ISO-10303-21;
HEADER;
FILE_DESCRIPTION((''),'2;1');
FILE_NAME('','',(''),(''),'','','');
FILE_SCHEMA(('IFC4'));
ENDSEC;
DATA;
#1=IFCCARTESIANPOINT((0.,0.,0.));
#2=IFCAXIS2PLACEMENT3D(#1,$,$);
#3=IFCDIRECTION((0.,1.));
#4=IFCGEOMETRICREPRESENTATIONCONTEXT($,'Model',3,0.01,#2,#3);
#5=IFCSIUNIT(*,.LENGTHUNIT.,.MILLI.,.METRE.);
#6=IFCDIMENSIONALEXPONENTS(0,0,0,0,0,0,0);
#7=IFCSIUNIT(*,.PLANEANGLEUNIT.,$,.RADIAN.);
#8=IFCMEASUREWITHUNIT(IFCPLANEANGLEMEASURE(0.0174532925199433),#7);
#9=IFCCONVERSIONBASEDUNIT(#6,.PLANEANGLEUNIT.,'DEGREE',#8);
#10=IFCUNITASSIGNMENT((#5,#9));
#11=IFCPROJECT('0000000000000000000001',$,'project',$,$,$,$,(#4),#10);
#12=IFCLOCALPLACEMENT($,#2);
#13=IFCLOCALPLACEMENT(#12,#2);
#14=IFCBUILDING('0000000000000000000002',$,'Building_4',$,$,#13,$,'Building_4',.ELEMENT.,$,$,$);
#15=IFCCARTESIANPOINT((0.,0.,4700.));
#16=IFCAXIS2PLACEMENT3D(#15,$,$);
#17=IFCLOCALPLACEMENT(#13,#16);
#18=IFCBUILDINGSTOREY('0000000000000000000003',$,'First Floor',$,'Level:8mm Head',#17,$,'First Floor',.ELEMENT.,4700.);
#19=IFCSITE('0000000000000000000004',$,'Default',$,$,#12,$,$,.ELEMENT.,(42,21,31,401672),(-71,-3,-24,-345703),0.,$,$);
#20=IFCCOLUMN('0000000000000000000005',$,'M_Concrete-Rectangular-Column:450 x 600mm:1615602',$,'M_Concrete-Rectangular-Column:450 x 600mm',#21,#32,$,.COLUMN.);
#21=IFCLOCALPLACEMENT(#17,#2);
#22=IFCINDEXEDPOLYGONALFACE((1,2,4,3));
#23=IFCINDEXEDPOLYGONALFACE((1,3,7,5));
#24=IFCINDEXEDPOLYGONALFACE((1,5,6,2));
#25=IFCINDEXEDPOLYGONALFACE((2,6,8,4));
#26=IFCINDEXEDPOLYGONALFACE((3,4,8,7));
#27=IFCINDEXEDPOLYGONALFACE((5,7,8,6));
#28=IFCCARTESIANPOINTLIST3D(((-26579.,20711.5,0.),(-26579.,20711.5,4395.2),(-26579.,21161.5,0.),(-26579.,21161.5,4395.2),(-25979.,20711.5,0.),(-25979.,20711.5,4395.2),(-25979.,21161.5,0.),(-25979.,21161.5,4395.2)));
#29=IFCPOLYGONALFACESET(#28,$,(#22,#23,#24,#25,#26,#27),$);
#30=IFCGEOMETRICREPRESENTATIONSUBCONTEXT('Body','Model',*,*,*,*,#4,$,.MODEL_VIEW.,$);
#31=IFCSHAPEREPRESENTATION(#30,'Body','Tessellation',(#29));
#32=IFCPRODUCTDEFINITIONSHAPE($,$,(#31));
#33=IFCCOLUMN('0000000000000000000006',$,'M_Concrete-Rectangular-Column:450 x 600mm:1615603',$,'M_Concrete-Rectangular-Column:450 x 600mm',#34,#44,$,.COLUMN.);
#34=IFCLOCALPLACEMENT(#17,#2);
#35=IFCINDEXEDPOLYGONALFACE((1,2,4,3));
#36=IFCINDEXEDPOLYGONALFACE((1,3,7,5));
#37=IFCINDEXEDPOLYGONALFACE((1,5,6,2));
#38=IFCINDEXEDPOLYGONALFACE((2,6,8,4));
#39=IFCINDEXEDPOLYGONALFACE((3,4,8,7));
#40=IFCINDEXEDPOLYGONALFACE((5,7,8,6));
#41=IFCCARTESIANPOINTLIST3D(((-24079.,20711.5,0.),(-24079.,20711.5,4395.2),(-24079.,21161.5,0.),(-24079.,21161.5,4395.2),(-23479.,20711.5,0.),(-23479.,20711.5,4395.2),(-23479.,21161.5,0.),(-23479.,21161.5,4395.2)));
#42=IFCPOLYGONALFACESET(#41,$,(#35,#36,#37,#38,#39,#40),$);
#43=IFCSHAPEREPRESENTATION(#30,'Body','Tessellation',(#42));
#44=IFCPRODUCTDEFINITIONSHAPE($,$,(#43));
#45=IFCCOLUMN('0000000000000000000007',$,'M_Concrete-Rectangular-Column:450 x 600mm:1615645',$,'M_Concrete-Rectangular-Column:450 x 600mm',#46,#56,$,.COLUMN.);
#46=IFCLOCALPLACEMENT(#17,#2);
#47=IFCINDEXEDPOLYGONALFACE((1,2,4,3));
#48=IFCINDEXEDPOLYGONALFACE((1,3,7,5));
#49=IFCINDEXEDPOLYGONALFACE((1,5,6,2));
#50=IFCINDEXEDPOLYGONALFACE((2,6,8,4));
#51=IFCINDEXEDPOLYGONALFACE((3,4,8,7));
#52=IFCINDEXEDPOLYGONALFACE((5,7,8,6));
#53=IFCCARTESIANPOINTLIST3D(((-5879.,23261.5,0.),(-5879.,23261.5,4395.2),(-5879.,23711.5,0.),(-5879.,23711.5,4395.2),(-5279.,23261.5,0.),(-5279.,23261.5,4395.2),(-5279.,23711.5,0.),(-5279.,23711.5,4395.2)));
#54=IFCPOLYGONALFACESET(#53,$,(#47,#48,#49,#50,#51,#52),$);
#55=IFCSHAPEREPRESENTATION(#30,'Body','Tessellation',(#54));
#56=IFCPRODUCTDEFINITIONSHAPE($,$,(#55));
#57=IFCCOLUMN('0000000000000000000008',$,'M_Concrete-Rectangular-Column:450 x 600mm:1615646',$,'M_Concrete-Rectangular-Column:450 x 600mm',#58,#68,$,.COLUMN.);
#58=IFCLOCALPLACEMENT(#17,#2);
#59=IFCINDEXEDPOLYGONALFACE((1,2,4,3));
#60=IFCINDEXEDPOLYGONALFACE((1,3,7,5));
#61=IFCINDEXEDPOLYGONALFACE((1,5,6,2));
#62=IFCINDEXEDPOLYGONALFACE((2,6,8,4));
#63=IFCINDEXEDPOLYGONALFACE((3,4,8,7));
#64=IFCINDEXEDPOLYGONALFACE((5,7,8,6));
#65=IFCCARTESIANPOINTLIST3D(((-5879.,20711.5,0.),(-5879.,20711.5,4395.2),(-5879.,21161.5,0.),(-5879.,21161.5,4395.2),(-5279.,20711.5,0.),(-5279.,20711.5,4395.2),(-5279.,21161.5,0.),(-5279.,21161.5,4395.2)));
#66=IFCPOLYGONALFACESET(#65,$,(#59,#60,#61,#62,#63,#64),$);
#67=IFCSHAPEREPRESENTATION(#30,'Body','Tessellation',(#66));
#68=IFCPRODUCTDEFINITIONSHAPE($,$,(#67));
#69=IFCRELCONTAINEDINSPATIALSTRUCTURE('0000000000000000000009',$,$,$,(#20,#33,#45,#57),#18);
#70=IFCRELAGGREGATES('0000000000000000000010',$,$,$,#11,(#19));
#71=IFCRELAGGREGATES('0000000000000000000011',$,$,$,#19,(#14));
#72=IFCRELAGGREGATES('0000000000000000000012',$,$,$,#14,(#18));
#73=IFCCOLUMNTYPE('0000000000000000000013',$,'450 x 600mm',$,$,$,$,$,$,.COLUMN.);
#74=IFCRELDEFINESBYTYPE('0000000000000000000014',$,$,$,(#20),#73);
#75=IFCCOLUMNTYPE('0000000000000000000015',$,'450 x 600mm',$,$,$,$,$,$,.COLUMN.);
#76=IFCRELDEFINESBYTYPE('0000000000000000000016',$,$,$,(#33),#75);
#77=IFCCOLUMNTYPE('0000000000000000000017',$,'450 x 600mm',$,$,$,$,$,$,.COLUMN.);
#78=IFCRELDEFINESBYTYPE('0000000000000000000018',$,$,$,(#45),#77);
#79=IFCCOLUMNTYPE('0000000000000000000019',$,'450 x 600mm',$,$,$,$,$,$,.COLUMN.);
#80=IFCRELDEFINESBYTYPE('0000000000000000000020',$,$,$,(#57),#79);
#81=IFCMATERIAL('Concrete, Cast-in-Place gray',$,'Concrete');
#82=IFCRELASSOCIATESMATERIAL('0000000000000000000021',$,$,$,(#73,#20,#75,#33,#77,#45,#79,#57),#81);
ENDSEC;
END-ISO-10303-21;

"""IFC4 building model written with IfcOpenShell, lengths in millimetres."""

from ifc_helpers import new_model, entity, si_unit, converted_unit, direction, frame, origin, place, context, subcontext, project, spatial, indexed_curve, outline, extrude, source, transform, mapped, material, type_object, type_shapes, element, save


model = new_model("IFC4")

# Units and contexts
model_context = context("Model", 3, precision=0.01, world=origin(), true_north=direction((0.0, 1.0)))
body_context = subcontext(model_context, "Body", "Model", "MODEL_VIEW")
ifc_project = project(units=[si_unit("LENGTHUNIT", "METRE", prefix="MILLI"), converted_unit("PLANEANGLEUNIT", "DEGREE", entity("IfcPlaneAngleMeasure", 0.0174532925199433), si_unit("PLANEANGLEUNIT", "RADIAN"), dimensions=[0, 0, 0, 0, 0, 0, 0])], contexts=[model_context])

# Site, building, storey
site_placement = place(None, origin())
site = spatial("IfcSite", under=ifc_project, at=site_placement, Name="Default", CompositionType="ELEMENT", RefLatitude=(42, 21, 31, 401672), RefLongitude=(-71, -3, -24, -345703), RefElevation=0.0)
building_placement = place(site_placement, origin())
building = spatial("IfcBuilding", under=site, at=building_placement, Name="Building_4", LongName="Building_4", CompositionType="ELEMENT")
storey_placement = place(building_placement, frame((0.0, 0.0, 4700.0)))
storey = spatial("IfcBuildingStorey", under=building, at=storey_placement, Name="First Floor", ObjectType="Level:8mm Head", LongName="First Floor", CompositionType="ELEMENT", Elevation=4700.0)

# Columns
ifc_material = material(Name="Concrete, Cast-in-Place gray", Category="Concrete")
column_type_1 = type_object("IfcColumnType", Name="450 x 600mm", PredefinedType="COLUMN", material=ifc_material)
shared_shape_1 = source(origin(), body_context, "Body", "SweptSolid", [
    extrude(outline(indexed_curve([(-225.0, -300.0), (225.0, -300.0), (225.0, 300.0), (-225.0, 300.0), (-225.0, -300.0)], self_intersect=False)), frame((-26279.0, 20936.5, 4700.0), z_axis=(0.0, 0.0, 1.0), x_axis=(0.0, -1.0, 0.0)), (0.0, 0.0, 1.0), 4395.2),
])
type_shapes(column_type_1, [shared_shape_1])
column_1_placement = place(storey_placement, frame((0.0, 0.0, -4700.0)))
element("IfcColumn", 1, at=column_1_placement, inside=storey, type_object=column_type_1, material=ifc_material, Name="M_Concrete-Rectangular-Column:450 x 600mm:1615602", ObjectType="M_Concrete-Rectangular-Column:450 x 600mm", PredefinedType="COLUMN", context=body_context, shape_type="MappedRepresentation", body=[
    mapped(shared_shape_1, transform((0.0, 0.0, 0.0), scale=1.0)),
])
column_type_2 = type_object("IfcColumnType", Name="450 x 600mm", PredefinedType="COLUMN", material=ifc_material)
shared_shape_2 = source(origin(), body_context, "Body", "SweptSolid", [
    extrude(outline(indexed_curve([(-225.0, -300.0), (225.0, -300.0), (225.0, 300.0), (-225.0, 300.0), (-225.0, -300.0)], self_intersect=False)), frame((-23779.0, 20936.5, 4700.0), z_axis=(0.0, 0.0, 1.0), x_axis=(0.0, -1.0, 0.0)), (0.0, 0.0, 1.0), 4395.2),
])
type_shapes(column_type_2, [shared_shape_2])
column_2_placement = place(storey_placement, frame((0.0, 0.0, -4700.0)))
element("IfcColumn", 2, at=column_2_placement, inside=storey, type_object=column_type_2, material=ifc_material, Name="M_Concrete-Rectangular-Column:450 x 600mm:1615603", ObjectType="M_Concrete-Rectangular-Column:450 x 600mm", PredefinedType="COLUMN", context=body_context, shape_type="MappedRepresentation", body=[
    mapped(shared_shape_2, transform((0.0, 0.0, 0.0), scale=1.0)),
])
column_type_3 = type_object("IfcColumnType", Name="450 x 600mm", PredefinedType="COLUMN", material=ifc_material)
shared_shape_3 = source(origin(), body_context, "Body", "SweptSolid", [
    extrude(outline(indexed_curve([(-225.0, -300.0), (225.0, -300.0), (225.0, 300.0), (-225.0, 300.0), (-225.0, -300.0)], self_intersect=False)), frame((-5579.0, 23486.5, 4700.0), z_axis=(0.0, 0.0, 1.0), x_axis=(0.0, 1.0, 0.0)), (0.0, 0.0, 1.0), 4395.2),
])
type_shapes(column_type_3, [shared_shape_3])
column_3_placement = place(storey_placement, frame((0.0, 0.0, -4700.0)))
element("IfcColumn", 3, at=column_3_placement, inside=storey, type_object=column_type_3, material=ifc_material, Name="M_Concrete-Rectangular-Column:450 x 600mm:1615645", ObjectType="M_Concrete-Rectangular-Column:450 x 600mm", PredefinedType="COLUMN", context=body_context, shape_type="MappedRepresentation", body=[
    mapped(shared_shape_3, transform((0.0, 0.0, 0.0), scale=1.0)),
])
column_type_4 = type_object("IfcColumnType", Name="450 x 600mm", PredefinedType="COLUMN", material=ifc_material)
shared_shape_4 = source(origin(), body_context, "Body", "SweptSolid", [
    extrude(outline(indexed_curve([(-300.0, -225.0), (300.0, -225.0), (300.0, 225.0), (-300.0, 225.0), (-300.0, -225.0)], self_intersect=False)), frame((-5579.0, 20936.5, 4700.0), z_axis=(0.0, 0.0, 1.0), x_axis=(-1.0, 0.0, 0.0)), (0.0, 0.0, 1.0), 4395.2),
])
type_shapes(column_type_4, [shared_shape_4])
column_4_placement = place(storey_placement, frame((0.0, 0.0, -4700.0)))
element("IfcColumn", 4, at=column_4_placement, inside=storey, type_object=column_type_4, material=ifc_material, Name="M_Concrete-Rectangular-Column:450 x 600mm:1615646", ObjectType="M_Concrete-Rectangular-Column:450 x 600mm", PredefinedType="COLUMN", context=body_context, shape_type="MappedRepresentation", body=[
    mapped(shared_shape_4, transform((0.0, 0.0, 0.0), scale=1.0)),
])

save(model, "model.ifc")
